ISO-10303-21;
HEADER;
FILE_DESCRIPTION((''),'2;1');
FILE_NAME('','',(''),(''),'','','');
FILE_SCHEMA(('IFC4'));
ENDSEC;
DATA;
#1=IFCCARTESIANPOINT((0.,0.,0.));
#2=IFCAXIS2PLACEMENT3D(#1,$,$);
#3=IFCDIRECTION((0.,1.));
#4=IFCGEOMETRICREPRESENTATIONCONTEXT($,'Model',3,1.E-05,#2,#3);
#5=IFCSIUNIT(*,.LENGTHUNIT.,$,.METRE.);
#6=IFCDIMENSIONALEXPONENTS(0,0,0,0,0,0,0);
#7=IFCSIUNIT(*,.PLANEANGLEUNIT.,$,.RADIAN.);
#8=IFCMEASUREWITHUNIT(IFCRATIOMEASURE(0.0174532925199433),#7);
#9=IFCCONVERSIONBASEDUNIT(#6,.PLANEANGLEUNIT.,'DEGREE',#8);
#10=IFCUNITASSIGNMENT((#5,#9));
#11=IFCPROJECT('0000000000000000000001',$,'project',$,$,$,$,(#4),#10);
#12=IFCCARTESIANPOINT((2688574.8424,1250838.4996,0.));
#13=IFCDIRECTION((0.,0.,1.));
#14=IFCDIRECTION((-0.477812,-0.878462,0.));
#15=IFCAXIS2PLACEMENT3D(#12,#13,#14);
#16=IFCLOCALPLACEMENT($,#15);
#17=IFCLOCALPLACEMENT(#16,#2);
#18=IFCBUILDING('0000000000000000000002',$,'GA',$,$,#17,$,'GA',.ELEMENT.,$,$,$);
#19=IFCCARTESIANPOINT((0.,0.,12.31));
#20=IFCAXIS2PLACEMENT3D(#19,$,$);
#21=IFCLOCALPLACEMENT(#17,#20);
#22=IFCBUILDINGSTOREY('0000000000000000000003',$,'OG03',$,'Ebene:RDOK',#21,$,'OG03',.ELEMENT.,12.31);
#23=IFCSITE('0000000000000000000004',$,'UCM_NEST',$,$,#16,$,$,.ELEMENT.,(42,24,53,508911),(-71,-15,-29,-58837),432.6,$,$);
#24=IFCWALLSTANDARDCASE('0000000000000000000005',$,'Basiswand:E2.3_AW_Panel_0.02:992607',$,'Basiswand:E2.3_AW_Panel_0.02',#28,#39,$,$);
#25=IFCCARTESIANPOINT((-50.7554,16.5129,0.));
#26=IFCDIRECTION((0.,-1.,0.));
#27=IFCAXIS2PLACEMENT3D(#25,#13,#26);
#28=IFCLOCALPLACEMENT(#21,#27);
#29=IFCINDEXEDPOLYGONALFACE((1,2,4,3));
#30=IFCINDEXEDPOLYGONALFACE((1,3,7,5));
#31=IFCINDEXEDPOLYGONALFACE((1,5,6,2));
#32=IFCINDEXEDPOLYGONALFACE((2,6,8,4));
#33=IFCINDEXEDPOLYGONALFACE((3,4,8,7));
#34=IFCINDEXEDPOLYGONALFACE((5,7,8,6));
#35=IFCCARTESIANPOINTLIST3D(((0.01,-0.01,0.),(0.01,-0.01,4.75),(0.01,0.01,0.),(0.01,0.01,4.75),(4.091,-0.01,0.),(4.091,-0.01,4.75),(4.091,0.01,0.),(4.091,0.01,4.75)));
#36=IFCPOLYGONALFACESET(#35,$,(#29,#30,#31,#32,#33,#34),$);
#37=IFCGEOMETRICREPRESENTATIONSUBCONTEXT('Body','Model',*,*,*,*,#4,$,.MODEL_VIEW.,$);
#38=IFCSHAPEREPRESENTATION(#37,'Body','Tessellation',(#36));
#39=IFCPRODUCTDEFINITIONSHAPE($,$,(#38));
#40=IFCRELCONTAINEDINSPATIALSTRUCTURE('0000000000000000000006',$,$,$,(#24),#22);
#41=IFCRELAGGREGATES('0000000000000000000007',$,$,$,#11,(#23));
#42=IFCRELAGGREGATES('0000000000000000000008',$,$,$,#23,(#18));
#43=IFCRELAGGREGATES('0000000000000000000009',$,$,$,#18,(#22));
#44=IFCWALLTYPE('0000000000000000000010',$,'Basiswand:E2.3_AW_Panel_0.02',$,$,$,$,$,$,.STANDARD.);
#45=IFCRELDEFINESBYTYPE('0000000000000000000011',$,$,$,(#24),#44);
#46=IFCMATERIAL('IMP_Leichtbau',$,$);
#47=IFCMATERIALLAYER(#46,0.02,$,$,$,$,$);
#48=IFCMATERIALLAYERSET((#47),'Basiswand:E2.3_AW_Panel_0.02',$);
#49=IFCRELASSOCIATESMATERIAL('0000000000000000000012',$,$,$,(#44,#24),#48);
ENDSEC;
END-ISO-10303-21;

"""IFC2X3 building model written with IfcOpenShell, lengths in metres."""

from ifc_helpers import new_model, entity, si_unit, converted_unit, direction, frame, frame_2d, origin, place, context, subcontext, project, spatial, rectangle, extrude, material, layer, layer_set, layer_usage, type_object, element, save


model = new_model("IFC2X3")

# Units and contexts
model_context = context("Model", 3, precision=1e-05, world=origin(), true_north=direction((0.0, 1.0)))
body_context = subcontext(model_context, "Body", "Model", "MODEL_VIEW")
ifc_project = project(units=[si_unit("LENGTHUNIT", "METRE"), converted_unit("PLANEANGLEUNIT", "DEGREE", entity("IfcRatioMeasure", 0.0174532925199433), si_unit("PLANEANGLEUNIT", "RADIAN"), dimensions=[0, 0, 0, 0, 0, 0, 0])], contexts=[model_context])

# Site, building, storey
site_placement = place(None, frame((2688574.8424, 1250838.4996, 0.0), z_axis=(0.0, 0.0, 1.0), x_axis=(-0.477812, -0.878462, 0.0)))
site = spatial("IfcSite", under=ifc_project, at=site_placement, Name="UCM_NEST", CompositionType="ELEMENT", RefLatitude=(42, 24, 53, 508911), RefLongitude=(-71, -15, -29, -58837), RefElevation=432.6)
building_placement = place(site_placement, origin())
building = spatial("IfcBuilding", under=site, at=building_placement, Name="GA", LongName="GA", CompositionType="ELEMENT")
storey_placement = place(building_placement, frame((0.0, 0.0, 12.31)))
storey = spatial("IfcBuildingStorey", under=building, at=storey_placement, Name="OG03", ObjectType="Ebene:RDOK", LongName="OG03", CompositionType="ELEMENT", Elevation=12.31)

# Wall
ifc_material_1 = material(Name="IMP_Leichtbau")
ifc_layer_1 = layer(ifc_material_1, 0.02)
ifc_layer_set_1 = layer_set([ifc_layer_1], Name="Basiswand:E2.3_AW_Panel_0.02")
wall_type_1 = type_object("IfcWallType", Name="Basiswand:E2.3_AW_Panel_0.02", PredefinedType="STANDARD", material=ifc_layer_set_1)
ifc_layer_usage_1 = layer_usage(ifc_layer_set_1, "AXIS2", "NEGATIVE", 0.01)
wall_1_placement = place(storey_placement, frame((-50.7554, 16.5129, 0.0), z_axis=(0.0, 0.0, 1.0), x_axis=(0.0, -1.0, 0.0)))
element("IfcWallStandardCase", 1, at=wall_1_placement, inside=storey, type_object=wall_type_1, material=ifc_layer_usage_1, Name="Basiswand:E2.3_AW_Panel_0.02:992607", ObjectType="Basiswand:E2.3_AW_Panel_0.02", context=body_context, shape_type="SweptSolid", body=[
    extrude(rectangle(XDim=4.081, YDim=0.02, at=frame_2d((2.0505, 0.0), x_axis=(-1.0, 0.0))), origin(), (0.0, 0.0, 1.0), 4.75),
])

save(model, "model.ifc")
